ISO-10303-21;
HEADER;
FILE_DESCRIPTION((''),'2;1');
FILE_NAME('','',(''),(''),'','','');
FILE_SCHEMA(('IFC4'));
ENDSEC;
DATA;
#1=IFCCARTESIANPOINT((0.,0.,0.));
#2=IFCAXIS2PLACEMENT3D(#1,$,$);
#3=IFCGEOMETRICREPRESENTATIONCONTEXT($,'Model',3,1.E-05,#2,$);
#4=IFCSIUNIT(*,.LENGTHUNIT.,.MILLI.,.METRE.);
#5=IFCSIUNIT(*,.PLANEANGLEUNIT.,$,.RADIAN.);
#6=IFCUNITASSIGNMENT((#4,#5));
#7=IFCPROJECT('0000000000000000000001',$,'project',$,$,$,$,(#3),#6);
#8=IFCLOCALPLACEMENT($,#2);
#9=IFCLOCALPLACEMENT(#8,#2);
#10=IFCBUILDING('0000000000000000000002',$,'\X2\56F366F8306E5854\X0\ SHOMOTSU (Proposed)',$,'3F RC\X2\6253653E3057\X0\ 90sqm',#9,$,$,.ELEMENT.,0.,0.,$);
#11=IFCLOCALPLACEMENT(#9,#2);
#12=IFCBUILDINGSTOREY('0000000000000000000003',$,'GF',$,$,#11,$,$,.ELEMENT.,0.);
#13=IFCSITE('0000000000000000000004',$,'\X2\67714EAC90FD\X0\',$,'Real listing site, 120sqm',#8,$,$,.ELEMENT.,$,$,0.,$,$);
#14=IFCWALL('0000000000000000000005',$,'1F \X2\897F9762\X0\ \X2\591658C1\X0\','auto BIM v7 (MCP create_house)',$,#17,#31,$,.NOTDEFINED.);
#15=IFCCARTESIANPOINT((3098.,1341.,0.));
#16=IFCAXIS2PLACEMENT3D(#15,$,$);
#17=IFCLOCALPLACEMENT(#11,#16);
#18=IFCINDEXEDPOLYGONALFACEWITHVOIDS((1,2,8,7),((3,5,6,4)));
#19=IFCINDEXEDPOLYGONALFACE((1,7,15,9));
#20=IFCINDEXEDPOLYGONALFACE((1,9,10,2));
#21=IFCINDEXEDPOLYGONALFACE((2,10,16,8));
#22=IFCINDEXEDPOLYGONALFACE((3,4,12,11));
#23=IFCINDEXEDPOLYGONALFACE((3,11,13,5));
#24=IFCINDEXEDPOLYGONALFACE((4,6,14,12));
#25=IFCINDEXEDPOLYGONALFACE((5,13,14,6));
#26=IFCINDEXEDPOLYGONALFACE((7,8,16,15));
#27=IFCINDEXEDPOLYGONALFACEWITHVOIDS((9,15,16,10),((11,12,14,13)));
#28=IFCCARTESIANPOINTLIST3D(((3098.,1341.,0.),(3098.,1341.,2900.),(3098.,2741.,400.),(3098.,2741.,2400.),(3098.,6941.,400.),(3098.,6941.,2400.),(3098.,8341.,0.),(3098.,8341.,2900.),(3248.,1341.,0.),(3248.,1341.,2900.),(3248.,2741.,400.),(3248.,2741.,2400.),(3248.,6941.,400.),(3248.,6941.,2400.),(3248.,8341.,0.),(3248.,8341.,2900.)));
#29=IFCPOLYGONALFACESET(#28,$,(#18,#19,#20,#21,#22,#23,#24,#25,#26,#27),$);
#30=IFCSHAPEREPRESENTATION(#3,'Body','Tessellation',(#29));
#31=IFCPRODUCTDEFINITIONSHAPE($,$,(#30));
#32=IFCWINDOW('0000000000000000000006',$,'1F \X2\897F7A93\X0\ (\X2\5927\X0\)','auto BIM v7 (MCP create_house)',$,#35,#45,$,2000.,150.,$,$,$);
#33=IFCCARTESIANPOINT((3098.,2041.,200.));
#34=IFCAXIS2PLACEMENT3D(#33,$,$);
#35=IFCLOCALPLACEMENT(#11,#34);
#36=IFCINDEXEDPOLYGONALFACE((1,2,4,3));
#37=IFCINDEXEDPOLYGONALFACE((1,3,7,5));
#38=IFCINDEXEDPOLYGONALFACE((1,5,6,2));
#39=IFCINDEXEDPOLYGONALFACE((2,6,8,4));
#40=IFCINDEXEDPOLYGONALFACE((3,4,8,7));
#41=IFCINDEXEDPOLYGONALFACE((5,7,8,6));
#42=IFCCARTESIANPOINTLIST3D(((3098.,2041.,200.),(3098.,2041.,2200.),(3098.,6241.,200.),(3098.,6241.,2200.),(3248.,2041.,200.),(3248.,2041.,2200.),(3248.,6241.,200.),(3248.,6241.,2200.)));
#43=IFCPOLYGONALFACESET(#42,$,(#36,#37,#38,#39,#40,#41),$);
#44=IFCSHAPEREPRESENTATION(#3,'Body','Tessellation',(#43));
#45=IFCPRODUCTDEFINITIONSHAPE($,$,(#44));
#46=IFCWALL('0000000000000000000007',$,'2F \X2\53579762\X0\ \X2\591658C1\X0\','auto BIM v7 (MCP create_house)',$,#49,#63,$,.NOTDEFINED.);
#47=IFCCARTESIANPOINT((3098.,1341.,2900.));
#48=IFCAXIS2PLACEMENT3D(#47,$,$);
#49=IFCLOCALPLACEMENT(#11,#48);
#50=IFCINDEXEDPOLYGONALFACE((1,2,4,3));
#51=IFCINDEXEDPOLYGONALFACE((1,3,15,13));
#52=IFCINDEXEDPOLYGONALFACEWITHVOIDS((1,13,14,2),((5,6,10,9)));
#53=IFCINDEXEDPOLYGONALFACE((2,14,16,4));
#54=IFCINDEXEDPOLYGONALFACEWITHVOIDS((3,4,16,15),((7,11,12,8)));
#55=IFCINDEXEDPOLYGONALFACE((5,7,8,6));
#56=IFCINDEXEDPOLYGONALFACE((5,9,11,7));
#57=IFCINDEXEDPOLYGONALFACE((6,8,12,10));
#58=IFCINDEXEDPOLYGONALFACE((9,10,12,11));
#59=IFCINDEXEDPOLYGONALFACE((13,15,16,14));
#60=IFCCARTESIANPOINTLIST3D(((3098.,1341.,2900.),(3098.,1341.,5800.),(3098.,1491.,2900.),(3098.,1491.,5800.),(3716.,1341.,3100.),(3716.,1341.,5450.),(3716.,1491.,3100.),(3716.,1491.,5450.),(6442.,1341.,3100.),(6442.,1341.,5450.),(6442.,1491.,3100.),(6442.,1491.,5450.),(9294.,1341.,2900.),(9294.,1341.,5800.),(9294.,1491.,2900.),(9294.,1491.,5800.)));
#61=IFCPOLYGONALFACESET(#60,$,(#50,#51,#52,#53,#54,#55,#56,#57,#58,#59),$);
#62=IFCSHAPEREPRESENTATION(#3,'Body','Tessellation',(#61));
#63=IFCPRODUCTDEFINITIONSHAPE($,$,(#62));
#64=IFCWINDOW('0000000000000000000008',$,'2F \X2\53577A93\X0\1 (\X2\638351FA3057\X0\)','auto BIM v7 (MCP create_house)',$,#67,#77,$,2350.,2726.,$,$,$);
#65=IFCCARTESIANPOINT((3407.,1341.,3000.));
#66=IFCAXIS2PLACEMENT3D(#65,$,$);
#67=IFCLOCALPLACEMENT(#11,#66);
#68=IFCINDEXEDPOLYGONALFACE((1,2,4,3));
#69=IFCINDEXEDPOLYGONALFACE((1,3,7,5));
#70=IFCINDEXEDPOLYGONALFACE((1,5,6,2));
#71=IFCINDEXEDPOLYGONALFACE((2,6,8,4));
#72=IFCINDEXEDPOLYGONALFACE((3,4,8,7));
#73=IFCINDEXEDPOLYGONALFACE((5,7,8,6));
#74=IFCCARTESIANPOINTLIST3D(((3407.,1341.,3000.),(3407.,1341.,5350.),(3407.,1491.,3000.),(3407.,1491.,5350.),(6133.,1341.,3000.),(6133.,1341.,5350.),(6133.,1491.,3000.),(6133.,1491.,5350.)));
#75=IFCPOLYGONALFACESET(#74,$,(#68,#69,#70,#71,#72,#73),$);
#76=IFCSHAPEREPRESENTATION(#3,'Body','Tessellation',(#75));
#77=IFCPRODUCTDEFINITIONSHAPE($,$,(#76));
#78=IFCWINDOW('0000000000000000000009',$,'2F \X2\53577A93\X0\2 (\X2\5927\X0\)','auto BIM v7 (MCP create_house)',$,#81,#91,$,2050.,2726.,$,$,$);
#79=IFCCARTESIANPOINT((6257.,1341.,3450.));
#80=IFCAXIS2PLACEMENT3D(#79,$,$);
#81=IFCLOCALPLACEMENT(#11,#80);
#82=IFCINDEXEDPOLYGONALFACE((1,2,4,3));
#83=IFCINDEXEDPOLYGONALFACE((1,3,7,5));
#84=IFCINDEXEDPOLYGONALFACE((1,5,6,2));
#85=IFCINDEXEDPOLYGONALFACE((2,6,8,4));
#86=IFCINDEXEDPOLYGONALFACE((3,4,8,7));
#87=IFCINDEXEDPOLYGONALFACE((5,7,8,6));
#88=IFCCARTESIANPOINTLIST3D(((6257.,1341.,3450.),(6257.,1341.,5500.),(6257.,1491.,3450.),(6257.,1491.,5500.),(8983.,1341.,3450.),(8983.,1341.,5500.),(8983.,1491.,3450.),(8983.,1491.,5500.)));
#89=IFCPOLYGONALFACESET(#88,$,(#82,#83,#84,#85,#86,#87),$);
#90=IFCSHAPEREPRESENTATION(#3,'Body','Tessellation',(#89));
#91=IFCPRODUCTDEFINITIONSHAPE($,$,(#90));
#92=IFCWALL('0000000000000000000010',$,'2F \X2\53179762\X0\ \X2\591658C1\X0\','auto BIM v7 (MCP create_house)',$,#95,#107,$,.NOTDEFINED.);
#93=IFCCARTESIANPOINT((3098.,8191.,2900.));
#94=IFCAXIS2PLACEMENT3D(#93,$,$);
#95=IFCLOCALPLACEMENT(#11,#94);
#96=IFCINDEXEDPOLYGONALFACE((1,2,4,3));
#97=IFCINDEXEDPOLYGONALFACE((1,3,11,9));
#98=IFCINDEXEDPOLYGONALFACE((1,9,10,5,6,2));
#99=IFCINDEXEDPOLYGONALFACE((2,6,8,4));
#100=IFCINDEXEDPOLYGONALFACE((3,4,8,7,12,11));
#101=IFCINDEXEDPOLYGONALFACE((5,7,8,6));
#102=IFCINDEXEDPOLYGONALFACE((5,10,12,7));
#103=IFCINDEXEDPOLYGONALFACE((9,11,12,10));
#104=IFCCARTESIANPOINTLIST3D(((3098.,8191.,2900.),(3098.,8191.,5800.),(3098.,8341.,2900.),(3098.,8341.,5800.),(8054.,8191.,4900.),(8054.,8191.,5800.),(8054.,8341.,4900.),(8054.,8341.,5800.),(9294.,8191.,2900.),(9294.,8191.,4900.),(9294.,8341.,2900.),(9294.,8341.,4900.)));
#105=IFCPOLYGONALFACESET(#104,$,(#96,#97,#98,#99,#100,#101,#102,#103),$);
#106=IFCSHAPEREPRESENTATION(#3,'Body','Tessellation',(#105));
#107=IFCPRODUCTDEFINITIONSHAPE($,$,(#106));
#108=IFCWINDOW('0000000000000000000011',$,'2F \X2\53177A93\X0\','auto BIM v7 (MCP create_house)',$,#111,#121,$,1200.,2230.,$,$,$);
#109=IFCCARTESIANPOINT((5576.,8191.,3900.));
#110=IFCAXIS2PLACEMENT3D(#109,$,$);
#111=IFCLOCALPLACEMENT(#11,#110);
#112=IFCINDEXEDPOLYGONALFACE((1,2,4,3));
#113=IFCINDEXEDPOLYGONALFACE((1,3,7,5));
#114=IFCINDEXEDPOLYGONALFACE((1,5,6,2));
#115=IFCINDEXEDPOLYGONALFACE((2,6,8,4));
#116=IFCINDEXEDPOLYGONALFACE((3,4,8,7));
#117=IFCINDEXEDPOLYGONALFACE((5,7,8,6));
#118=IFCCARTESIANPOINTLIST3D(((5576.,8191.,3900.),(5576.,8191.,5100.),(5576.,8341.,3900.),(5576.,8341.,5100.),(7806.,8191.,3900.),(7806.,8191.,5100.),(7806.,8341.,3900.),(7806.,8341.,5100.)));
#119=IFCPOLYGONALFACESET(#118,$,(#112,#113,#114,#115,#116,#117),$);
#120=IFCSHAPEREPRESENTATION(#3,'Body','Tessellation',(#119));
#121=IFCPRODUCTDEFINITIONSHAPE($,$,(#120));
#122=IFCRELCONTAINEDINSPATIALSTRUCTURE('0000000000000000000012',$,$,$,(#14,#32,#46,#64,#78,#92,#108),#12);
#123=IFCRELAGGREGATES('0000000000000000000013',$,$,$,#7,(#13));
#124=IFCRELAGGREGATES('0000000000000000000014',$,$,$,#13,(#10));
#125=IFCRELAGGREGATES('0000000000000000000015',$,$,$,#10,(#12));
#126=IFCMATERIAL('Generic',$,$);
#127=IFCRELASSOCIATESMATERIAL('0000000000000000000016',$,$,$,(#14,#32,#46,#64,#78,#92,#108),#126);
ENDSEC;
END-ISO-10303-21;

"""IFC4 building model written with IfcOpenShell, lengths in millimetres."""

from ifc_helpers import new_model, si_unit, frame, frame_2d, origin, place, context, project, spatial, rectangle, extrude, material, element, fill, save


model = new_model("IFC4")

# Units and contexts
model_context = context("Model", 3, precision=1e-05, world=origin())
ifc_project = project(units=[si_unit("LENGTHUNIT", "METRE", prefix="MILLI"), si_unit("PLANEANGLEUNIT", "RADIAN")], contexts=[model_context])

# Site, building, storey
site_placement = place(None, origin())
site = spatial("IfcSite", under=ifc_project, at=site_placement, Name="東京都", ObjectType="Real listing site, 120sqm", CompositionType="ELEMENT", RefElevation=0.0)
building_placement = place(site_placement, origin())
building = spatial("IfcBuilding", under=site, at=building_placement, Name="図書の塔 SHOMOTSU (Proposed)", ObjectType="3F RC打放し 90sqm", CompositionType="ELEMENT", ElevationOfRefHeight=0.0, ElevationOfTerrain=0.0)
storey_placement = place(building_placement, origin())
storey = spatial("IfcBuildingStorey", under=building, at=storey_placement, Name="GF", CompositionType="ELEMENT", Elevation=0.0)

# Shared definitions
ifc_material = material(Name="Generic")

# Wall, opening, window
wall_1_placement = place(storey_placement, frame((3098.0, 1341.0, 0.0)))
wall_1 = element("IfcWall", 1, at=wall_1_placement, inside=storey, material=ifc_material, Name="1F 西面 外壁", Description="auto BIM v7 (MCP create_house)", PredefinedType="NOTDEFINED", context=model_context, shape_type="SweptSolid", body=[
    extrude(rectangle(XDim=150.0, YDim=7000.0, at=frame_2d((75.0, 3500.0))), frame((3098.0, 1341.0, 0.0)), (0.0, 0.0, 1.0), 2900.0),
])
opening_1_placement = place(storey_placement, frame((3098.0, 2041.0, 200.0)))
opening_1 = element("IfcOpeningElement", 2, at=opening_1_placement, cuts=wall_1, PredefinedType="NOTDEFINED", context=model_context, shape_type="SweptSolid", body=[
    extrude(rectangle(XDim=150.0, YDim=4200.0, at=frame_2d((75.0, 2100.0))), frame((3098.0, 2041.0, 200.0)), (0.0, 0.0, 1.0), 2000.0),
])
window_1_placement = place(storey_placement, frame((3098.0, 2041.0, 200.0)))
window_1 = element("IfcWindow", 3, at=window_1_placement, inside=storey, material=ifc_material, Name="1F 西窓 (大)", Description="auto BIM v7 (MCP create_house)", OverallHeight=2000.0, OverallWidth=150.0, context=model_context, shape_type="SweptSolid", body=[
    extrude(rectangle(XDim=150.0, YDim=4200.0, at=frame_2d((75.0, 2100.0))), frame((3098.0, 2041.0, 200.0)), (0.0, 0.0, 1.0), 2000.0),
])
fill(opening_1, window_1)

# Wall, openings, windows
wall_2_placement = place(storey_placement, frame((3098.0, 1341.0, 2900.0)))
wall_2 = element("IfcWall", 4, at=wall_2_placement, inside=storey, material=ifc_material, Name="2F 南面 外壁", Description="auto BIM v7 (MCP create_house)", PredefinedType="NOTDEFINED", context=model_context, shape_type="SweptSolid", body=[
    extrude(rectangle(XDim=6196.0, YDim=150.0, at=frame_2d((3098.0, 75.0))), frame((3098.0, 1341.0, 2900.0)), (0.0, 0.0, 1.0), 2900.0),
])
opening_2_placement = place(storey_placement, frame((3407.0, 1341.0, 3000.0)))
opening_2 = element("IfcOpeningElement", 5, at=opening_2_placement, cuts=wall_2, PredefinedType="NOTDEFINED", context=model_context, shape_type="SweptSolid", body=[
    extrude(rectangle(XDim=2726.0, YDim=150.0, at=frame_2d((1363.0, 75.0))), frame((3407.0, 1341.0, 3000.0)), (0.0, 0.0, 1.0), 2350.0),
])
opening_3_placement = place(storey_placement, frame((6257.0, 1341.0, 3450.0)))
opening_3 = element("IfcOpeningElement", 6, at=opening_3_placement, cuts=wall_2, PredefinedType="NOTDEFINED", context=model_context, shape_type="SweptSolid", body=[
    extrude(rectangle(XDim=2726.0, YDim=150.0, at=frame_2d((1363.0, 75.0))), frame((6257.0, 1341.0, 3450.0)), (0.0, 0.0, 1.0), 2050.0),
])
window_2_placement = place(storey_placement, frame((3407.0, 1341.0, 3000.0)))
window_2 = element("IfcWindow", 7, at=window_2_placement, inside=storey, material=ifc_material, Name="2F 南窓1 (掃出し)", Description="auto BIM v7 (MCP create_house)", OverallHeight=2350.0, OverallWidth=2726.0, context=model_context, shape_type="SweptSolid", body=[
    extrude(rectangle(XDim=2726.0, YDim=150.0, at=frame_2d((1363.0, 75.0))), frame((3407.0, 1341.0, 3000.0)), (0.0, 0.0, 1.0), 2350.0),
])
fill(opening_2, window_2)
window_3_placement = place(storey_placement, frame((6257.0, 1341.0, 3450.0)))
window_3 = element("IfcWindow", 8, at=window_3_placement, inside=storey, material=ifc_material, Name="2F 南窓2 (大)", Description="auto BIM v7 (MCP create_house)", OverallHeight=2050.0, OverallWidth=2726.0, context=model_context, shape_type="SweptSolid", body=[
    extrude(rectangle(XDim=2726.0, YDim=150.0, at=frame_2d((1363.0, 75.0))), frame((6257.0, 1341.0, 3450.0)), (0.0, 0.0, 1.0), 2050.0),
])
fill(opening_3, window_3)

# Wall, opening, window
wall_3_placement = place(storey_placement, frame((3098.0, 8191.0, 2900.0)))
wall_3 = element("IfcWall", 9, at=wall_3_placement, inside=storey, material=ifc_material, Name="2F 北面 外壁", Description="auto BIM v7 (MCP create_house)", PredefinedType="NOTDEFINED", context=model_context, shape_type="SweptSolid", body=[
    extrude(rectangle(XDim=6196.0, YDim=150.0, at=frame_2d((3098.0, 75.0))), frame((3098.0, 8191.0, 2900.0)), (0.0, 0.0, 1.0), 2900.0),
])
opening_4_placement = place(storey_placement, frame((5576.0, 8191.0, 3900.0)))
opening_4 = element("IfcOpeningElement", 10, at=opening_4_placement, cuts=wall_3, PredefinedType="NOTDEFINED", context=model_context, shape_type="SweptSolid", body=[
    extrude(rectangle(XDim=2230.0, YDim=150.0, at=frame_2d((1115.0, 75.0))), frame((5576.0, 8191.0, 3900.0)), (0.0, 0.0, 1.0), 1200.0),
])
window_4_placement = place(storey_placement, frame((5576.0, 8191.0, 3900.0)))
window_4 = element("IfcWindow", 11, at=window_4_placement, inside=storey, material=ifc_material, Name="2F 北窓", Description="auto BIM v7 (MCP create_house)", OverallHeight=1200.0, OverallWidth=2230.0, context=model_context, shape_type="SweptSolid", body=[
    extrude(rectangle(XDim=2230.0, YDim=150.0, at=frame_2d((1115.0, 75.0))), frame((5576.0, 8191.0, 3900.0)), (0.0, 0.0, 1.0), 1200.0),
])
fill(opening_4, window_4)

save(model, "model.ifc")
